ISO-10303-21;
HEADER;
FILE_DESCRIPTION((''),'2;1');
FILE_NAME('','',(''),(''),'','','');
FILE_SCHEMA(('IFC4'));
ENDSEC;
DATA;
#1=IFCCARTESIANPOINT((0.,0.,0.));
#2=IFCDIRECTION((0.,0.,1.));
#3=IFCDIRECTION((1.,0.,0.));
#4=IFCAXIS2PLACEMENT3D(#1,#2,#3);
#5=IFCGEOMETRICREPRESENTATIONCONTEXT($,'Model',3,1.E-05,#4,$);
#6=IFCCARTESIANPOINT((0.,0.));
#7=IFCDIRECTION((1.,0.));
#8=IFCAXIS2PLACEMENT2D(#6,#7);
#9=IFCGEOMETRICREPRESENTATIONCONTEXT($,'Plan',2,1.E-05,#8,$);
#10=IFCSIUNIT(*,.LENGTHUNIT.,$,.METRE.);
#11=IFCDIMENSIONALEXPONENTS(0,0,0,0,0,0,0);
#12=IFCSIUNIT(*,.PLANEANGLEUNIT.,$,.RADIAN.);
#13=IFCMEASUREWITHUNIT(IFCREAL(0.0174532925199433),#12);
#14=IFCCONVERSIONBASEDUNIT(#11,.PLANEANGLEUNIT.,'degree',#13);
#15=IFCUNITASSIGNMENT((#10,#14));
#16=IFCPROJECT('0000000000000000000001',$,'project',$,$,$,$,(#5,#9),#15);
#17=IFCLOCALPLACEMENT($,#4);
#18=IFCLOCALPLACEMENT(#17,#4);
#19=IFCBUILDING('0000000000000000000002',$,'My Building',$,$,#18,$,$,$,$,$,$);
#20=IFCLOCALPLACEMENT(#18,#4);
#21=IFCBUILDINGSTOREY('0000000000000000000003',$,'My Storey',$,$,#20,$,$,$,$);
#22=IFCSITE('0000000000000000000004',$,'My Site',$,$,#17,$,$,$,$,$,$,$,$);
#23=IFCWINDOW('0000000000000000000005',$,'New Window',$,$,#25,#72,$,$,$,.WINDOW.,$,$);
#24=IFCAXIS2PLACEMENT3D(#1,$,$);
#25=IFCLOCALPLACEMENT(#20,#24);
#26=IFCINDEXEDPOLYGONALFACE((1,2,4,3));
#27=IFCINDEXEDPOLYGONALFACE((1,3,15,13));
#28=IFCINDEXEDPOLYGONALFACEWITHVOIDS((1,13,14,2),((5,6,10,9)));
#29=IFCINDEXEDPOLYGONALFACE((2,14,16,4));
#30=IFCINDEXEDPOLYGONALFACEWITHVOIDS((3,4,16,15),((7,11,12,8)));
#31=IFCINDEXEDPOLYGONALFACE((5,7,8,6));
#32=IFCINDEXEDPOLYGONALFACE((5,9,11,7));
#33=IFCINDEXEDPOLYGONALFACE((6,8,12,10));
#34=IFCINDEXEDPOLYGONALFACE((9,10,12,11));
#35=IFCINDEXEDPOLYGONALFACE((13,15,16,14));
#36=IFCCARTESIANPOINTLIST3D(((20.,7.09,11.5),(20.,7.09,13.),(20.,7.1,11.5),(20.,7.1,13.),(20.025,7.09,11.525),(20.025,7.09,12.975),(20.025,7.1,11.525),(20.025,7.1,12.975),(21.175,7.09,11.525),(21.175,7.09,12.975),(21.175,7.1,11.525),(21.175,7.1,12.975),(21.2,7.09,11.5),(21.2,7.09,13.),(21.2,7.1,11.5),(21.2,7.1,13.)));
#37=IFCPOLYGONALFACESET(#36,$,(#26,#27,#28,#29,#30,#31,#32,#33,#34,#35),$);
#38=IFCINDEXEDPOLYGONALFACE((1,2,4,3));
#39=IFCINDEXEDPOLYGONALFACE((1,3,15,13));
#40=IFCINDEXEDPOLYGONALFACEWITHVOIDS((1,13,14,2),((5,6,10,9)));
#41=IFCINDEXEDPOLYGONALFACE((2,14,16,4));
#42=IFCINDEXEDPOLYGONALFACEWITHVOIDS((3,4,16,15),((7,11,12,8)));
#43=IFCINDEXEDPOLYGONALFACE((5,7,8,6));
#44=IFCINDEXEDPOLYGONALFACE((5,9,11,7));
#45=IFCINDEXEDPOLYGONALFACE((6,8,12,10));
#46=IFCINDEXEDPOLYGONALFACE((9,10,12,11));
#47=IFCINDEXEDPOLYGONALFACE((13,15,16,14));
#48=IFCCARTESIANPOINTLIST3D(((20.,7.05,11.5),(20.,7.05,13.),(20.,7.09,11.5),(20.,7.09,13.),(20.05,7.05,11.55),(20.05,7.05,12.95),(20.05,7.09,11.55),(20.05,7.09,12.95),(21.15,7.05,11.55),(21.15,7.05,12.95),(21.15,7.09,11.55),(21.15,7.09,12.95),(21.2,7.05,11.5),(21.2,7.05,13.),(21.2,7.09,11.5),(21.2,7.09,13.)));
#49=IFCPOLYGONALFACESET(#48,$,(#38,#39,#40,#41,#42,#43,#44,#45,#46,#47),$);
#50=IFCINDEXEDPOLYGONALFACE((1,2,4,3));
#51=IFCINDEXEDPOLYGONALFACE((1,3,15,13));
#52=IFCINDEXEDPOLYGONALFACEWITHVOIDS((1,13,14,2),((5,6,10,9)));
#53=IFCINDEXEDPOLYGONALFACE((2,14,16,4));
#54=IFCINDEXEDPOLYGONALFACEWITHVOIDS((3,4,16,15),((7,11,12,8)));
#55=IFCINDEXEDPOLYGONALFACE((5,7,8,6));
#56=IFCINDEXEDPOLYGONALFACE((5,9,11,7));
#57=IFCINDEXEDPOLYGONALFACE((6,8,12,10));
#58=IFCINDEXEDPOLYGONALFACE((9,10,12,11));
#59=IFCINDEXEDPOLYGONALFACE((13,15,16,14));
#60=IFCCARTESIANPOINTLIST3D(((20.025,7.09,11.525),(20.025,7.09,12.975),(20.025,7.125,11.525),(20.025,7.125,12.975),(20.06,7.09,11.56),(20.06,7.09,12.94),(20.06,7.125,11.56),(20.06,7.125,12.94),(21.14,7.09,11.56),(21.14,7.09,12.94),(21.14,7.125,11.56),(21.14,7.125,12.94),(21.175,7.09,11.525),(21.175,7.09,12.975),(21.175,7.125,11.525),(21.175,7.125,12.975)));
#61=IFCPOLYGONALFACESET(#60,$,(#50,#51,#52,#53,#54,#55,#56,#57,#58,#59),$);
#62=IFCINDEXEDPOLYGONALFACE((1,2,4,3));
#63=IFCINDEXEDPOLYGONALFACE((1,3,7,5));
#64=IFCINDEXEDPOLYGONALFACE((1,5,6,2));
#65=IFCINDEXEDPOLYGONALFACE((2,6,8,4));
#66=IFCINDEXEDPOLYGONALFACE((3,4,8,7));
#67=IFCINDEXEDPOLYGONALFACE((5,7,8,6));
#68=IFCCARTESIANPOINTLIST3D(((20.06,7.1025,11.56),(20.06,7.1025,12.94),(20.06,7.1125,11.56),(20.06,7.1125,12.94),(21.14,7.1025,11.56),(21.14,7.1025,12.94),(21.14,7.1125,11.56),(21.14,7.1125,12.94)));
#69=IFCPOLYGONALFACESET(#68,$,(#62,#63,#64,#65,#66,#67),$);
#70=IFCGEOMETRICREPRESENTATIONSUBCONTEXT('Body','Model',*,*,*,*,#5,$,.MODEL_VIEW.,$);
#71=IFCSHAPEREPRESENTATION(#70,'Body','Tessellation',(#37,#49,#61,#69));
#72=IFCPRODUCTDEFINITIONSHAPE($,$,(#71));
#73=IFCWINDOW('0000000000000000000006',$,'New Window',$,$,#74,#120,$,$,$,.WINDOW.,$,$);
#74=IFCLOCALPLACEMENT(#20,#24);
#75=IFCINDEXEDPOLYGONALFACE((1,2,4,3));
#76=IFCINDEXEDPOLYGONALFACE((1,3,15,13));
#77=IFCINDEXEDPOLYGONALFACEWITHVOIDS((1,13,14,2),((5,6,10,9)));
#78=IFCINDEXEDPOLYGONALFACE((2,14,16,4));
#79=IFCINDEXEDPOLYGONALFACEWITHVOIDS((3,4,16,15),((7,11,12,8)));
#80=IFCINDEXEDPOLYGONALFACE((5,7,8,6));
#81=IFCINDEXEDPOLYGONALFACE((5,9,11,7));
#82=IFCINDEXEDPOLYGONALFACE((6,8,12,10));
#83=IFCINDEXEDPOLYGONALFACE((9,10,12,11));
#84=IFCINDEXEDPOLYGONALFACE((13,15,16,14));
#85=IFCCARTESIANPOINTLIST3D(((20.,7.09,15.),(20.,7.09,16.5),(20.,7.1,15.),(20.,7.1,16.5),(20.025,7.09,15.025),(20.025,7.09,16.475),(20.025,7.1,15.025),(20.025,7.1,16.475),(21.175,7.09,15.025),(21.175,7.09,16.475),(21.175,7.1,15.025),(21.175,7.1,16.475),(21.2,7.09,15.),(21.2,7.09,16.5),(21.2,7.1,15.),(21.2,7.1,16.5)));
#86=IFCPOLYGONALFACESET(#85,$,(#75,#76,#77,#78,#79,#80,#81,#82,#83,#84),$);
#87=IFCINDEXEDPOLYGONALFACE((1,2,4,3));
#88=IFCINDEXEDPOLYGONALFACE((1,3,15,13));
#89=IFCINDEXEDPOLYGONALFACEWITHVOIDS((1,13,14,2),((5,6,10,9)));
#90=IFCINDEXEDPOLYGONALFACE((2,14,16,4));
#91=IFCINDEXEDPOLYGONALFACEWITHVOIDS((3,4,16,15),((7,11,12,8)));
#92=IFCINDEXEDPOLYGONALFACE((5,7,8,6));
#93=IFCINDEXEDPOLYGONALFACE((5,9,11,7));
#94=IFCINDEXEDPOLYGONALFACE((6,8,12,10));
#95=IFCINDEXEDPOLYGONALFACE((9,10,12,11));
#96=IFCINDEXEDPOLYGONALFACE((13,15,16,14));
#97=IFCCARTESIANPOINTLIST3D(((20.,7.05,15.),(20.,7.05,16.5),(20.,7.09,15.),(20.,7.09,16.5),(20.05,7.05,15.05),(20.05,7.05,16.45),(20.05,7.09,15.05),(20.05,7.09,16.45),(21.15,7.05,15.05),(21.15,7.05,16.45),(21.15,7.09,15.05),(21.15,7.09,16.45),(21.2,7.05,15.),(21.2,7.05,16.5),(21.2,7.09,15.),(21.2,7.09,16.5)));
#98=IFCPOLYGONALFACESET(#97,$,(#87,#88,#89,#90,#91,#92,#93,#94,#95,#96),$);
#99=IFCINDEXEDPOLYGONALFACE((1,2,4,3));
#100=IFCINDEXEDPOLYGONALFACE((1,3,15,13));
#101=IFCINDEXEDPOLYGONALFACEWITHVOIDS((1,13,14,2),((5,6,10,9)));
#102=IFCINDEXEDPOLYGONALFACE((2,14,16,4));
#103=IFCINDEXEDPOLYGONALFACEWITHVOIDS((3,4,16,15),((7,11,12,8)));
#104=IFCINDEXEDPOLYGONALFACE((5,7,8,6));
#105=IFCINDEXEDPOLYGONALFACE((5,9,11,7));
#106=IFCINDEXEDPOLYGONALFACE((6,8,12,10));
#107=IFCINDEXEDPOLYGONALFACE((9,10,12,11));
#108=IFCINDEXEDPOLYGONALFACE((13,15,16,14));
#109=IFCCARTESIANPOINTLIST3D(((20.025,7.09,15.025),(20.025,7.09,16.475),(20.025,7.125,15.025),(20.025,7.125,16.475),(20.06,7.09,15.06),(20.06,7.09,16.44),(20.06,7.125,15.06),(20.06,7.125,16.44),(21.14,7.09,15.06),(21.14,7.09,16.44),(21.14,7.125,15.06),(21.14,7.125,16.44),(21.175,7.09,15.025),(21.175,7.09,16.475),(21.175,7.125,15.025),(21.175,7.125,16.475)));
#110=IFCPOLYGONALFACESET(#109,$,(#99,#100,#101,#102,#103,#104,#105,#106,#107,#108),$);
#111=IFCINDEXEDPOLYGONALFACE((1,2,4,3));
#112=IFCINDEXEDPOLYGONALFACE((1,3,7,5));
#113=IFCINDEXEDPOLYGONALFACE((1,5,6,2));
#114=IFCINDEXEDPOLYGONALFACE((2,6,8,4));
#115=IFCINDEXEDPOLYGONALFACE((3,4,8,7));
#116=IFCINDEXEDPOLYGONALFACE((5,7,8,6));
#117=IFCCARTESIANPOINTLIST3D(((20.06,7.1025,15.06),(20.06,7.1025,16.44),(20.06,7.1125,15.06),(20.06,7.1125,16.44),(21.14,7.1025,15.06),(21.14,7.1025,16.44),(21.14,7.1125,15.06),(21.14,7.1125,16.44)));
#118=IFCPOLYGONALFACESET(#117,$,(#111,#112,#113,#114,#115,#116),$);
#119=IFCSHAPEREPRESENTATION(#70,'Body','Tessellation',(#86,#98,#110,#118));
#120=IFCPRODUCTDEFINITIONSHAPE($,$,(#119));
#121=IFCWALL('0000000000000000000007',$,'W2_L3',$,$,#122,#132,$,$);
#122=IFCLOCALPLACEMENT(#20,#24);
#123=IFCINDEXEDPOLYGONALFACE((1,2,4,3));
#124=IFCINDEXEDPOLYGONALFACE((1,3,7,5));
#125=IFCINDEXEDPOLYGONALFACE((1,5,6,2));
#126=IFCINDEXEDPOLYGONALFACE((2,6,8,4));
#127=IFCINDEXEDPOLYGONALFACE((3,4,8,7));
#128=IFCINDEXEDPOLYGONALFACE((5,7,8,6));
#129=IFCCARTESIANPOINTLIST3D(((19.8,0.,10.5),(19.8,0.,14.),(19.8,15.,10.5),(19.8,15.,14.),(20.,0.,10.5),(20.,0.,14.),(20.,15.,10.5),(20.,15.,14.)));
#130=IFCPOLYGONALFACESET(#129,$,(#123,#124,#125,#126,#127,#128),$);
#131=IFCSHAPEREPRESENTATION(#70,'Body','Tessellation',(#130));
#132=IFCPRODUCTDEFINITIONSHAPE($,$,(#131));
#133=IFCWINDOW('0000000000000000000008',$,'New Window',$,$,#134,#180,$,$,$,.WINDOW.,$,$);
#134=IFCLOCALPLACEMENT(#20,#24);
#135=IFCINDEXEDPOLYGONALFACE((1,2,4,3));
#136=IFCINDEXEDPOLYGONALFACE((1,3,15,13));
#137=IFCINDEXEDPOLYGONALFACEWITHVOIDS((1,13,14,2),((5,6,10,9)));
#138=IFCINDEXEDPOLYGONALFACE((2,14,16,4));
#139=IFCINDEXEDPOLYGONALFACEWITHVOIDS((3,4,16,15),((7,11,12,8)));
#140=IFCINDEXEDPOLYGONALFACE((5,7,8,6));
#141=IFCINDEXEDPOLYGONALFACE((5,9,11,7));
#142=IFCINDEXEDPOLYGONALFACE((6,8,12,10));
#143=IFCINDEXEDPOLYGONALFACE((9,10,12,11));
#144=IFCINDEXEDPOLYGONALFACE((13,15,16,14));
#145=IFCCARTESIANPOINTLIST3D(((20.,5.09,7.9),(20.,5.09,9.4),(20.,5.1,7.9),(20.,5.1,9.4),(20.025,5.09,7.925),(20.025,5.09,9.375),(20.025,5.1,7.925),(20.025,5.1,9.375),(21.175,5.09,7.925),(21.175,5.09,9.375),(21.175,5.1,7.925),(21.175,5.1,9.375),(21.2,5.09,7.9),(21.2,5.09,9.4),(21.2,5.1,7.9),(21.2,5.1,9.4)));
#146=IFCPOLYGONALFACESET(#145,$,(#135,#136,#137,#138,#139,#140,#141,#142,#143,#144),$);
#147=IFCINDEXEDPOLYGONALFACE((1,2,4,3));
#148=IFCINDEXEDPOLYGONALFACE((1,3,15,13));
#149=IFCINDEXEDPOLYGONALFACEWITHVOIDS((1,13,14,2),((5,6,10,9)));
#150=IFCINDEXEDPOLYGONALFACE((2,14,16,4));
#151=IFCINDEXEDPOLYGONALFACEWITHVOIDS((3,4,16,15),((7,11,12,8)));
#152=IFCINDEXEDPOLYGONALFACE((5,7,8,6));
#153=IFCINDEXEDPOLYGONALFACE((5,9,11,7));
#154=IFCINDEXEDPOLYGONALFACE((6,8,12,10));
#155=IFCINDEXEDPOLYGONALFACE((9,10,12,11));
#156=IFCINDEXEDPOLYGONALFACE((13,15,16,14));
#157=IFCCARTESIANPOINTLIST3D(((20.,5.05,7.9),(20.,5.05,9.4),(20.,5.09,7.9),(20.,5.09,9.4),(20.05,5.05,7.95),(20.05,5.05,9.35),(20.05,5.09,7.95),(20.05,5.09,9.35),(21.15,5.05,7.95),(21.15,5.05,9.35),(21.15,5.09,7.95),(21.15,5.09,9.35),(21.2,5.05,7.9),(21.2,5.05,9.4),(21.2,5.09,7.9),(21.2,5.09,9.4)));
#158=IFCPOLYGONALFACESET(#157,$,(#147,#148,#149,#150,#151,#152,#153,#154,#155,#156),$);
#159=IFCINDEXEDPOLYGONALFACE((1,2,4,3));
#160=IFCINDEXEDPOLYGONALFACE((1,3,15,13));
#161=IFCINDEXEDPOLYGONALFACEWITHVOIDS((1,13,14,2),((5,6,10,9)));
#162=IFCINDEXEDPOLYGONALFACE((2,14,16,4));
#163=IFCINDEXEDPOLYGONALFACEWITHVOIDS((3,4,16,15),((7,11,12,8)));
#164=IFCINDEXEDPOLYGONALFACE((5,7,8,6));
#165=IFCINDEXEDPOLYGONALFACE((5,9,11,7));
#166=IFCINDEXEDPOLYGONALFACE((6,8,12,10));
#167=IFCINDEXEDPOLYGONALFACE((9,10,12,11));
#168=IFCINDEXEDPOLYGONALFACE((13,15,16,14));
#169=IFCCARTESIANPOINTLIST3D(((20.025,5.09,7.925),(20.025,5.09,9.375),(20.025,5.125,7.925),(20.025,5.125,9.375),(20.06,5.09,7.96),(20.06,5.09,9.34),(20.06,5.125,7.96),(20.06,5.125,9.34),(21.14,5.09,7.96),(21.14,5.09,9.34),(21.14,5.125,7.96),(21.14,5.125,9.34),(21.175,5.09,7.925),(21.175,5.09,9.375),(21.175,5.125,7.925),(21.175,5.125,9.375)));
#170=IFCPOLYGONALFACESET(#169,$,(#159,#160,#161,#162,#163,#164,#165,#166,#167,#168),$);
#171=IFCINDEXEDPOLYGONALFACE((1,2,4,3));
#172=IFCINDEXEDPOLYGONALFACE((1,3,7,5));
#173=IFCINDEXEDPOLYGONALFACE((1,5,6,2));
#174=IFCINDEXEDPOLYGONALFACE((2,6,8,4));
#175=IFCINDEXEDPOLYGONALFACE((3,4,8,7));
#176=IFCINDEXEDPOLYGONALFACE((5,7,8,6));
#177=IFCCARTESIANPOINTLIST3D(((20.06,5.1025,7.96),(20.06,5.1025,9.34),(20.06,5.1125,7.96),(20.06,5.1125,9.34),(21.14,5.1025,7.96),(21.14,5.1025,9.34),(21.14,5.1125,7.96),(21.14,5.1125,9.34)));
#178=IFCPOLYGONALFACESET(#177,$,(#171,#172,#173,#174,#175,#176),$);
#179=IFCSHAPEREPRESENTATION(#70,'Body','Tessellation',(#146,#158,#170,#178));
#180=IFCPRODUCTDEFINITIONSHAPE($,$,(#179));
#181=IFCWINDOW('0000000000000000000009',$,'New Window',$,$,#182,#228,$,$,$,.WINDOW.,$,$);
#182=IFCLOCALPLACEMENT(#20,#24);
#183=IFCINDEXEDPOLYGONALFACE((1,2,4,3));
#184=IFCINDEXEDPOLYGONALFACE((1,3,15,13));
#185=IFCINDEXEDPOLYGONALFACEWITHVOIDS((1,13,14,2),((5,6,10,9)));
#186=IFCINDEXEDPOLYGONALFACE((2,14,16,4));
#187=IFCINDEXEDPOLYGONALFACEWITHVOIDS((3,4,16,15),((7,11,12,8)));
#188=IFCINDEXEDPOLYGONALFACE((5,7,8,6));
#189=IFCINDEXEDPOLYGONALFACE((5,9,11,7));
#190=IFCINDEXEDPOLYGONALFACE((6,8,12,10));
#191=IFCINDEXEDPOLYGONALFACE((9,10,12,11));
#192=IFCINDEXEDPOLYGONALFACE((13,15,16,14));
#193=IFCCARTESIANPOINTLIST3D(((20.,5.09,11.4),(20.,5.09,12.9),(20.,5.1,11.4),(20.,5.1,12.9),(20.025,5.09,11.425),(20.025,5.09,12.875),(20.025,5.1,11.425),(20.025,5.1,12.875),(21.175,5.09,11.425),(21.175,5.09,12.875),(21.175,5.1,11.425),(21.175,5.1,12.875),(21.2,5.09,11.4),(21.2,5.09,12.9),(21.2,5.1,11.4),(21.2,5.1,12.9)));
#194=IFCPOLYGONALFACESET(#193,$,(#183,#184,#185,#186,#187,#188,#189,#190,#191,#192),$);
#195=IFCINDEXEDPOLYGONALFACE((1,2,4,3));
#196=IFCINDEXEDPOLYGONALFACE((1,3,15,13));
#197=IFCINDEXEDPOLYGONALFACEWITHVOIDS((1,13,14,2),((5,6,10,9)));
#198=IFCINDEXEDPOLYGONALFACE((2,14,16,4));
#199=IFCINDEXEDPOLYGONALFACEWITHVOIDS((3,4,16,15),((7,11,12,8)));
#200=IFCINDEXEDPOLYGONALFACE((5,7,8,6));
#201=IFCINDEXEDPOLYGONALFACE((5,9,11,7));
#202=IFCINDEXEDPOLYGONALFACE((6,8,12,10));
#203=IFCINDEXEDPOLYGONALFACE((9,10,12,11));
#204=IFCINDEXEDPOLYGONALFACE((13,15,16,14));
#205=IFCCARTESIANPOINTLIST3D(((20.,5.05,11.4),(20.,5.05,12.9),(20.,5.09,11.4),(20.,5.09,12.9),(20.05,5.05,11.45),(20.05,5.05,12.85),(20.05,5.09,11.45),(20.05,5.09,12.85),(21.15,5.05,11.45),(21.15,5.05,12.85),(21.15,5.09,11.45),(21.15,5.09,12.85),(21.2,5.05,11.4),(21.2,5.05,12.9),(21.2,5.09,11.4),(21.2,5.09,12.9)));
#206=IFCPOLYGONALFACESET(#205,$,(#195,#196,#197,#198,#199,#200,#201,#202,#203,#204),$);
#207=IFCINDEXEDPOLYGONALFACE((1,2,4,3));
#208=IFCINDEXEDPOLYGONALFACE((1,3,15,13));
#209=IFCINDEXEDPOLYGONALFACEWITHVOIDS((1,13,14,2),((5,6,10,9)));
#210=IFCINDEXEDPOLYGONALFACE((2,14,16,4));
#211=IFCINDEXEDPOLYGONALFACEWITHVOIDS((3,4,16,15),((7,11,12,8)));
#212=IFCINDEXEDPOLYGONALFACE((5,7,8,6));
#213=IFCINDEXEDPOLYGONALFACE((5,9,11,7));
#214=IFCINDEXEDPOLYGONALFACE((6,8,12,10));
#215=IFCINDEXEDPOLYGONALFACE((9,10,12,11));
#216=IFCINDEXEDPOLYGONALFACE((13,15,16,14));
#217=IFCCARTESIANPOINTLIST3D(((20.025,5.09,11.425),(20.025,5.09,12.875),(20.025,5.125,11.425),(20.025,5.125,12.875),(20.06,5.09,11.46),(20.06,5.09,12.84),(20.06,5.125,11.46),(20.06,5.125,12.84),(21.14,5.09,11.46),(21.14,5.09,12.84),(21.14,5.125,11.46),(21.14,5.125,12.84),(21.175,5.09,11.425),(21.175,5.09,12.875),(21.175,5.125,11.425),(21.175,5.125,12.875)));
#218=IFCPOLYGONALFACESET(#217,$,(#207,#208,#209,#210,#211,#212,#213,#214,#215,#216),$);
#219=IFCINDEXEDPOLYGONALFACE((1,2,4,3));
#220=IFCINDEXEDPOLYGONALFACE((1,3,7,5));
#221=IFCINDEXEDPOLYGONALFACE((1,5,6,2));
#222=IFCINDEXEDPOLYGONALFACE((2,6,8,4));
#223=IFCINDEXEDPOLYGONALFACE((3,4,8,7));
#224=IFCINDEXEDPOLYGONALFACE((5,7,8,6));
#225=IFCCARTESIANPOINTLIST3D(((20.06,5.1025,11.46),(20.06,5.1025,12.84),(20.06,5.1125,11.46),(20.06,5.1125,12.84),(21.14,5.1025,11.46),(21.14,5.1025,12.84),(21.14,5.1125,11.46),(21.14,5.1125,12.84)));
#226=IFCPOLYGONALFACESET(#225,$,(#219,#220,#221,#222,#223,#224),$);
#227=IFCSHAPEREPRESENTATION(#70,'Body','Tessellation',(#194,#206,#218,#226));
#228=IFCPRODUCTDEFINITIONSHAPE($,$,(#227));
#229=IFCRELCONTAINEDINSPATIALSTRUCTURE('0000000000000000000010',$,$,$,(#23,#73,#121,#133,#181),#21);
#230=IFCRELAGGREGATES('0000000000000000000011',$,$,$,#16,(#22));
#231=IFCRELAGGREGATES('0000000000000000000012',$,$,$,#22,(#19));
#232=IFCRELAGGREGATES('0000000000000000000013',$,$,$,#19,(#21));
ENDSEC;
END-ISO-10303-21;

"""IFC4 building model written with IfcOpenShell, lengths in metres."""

from ifc_helpers import new_model, entity, si_unit, converted_unit, frame, origin_with_axes, origin_2d_with_axis, place, context, subcontext, project, spatial, line, indexed_curve, outline, extrude, element, save


model = new_model("IFC4")

# Units and contexts
model_context = context("Model", 3, precision=1e-05, world=origin_with_axes())
plan_context = context("Plan", 2, precision=1e-05, world=origin_2d_with_axis())
body_context = subcontext(model_context, "Body", "Model", "MODEL_VIEW")
ifc_project = project(units=[si_unit("LENGTHUNIT", "METRE"), converted_unit("PLANEANGLEUNIT", "degree", entity("IfcReal", 0.0174532925199433), si_unit("PLANEANGLEUNIT", "RADIAN"), dimensions=[0, 0, 0, 0, 0, 0, 0])], contexts=[model_context, plan_context])

# Site, building, storey
site_placement = place(None, origin_with_axes())
site = spatial("IfcSite", under=ifc_project, at=site_placement, Name="My Site")
building_placement = place(site_placement, origin_with_axes())
building = spatial("IfcBuilding", under=site, at=building_placement, Name="My Building")
storey_placement = place(building_placement, origin_with_axes())
storey = spatial("IfcBuildingStorey", under=building, at=storey_placement, Name="My Storey")

# Windows
for number, where, z_axis, x_axis, name in (
    (1, (20.0, 7.0, 11.5), (0.0, 0.0, 1.0), (1.0, 0.0, 0.0), "New Window"),
    (2, (20.0, 7.0, 15.0), (0.0, 0.0, 1.0), (1.0, 0.0, 0.0), "New Window"),
):
    element("IfcWindow", number, at=place(storey_placement, frame(where, z_axis=z_axis, x_axis=x_axis)), inside=storey, Name=name, PredefinedType="WINDOW", context=body_context, shape_type="SweptSolid", body=[
        extrude(outline(indexed_curve([(0.0, 0.0), (1.2, 0.0), (1.2, 1.5), (0.0, 1.5)], segments=[line(1, 2, 3, 4, 1)]), holes=[indexed_curve([(0.025, 0.025), (1.175, 0.025), (1.175, 1.475), (0.025, 1.475)], segments=[line(1, 2, 3, 4, 1)])]), frame((0.0, 0.09, 0.0), z_axis=(0.0, -1.0, 0.0), x_axis=(1.0, 0.0, 0.0)), (0.0, 0.0, -1.0), 0.01),
        extrude(outline(indexed_curve([(0.0, 0.0), (1.2, 0.0), (1.2, 1.5), (0.0, 1.5)], segments=[line(1, 2, 3, 4, 1)]), holes=[indexed_curve([(0.05, 0.05), (1.15, 0.05), (1.15, 1.45), (0.05, 1.45)], segments=[line(1, 2, 3, 4, 1)])]), frame((0.0, 0.05, 0.0), z_axis=(0.0, -1.0, 0.0), x_axis=(1.0, 0.0, 0.0)), (0.0, 0.0, -1.0), 0.04),
        extrude(outline(indexed_curve([(0.0, 0.0), (1.15, 0.0), (1.15, 1.45), (0.0, 1.45)], segments=[line(1, 2, 3, 4, 1)]), holes=[indexed_curve([(0.035, 0.035), (1.115, 0.035), (1.115, 1.415), (0.035, 1.415)], segments=[line(1, 2, 3, 4, 1)])]), frame((0.025, 0.09, 0.025), z_axis=(0.0, -1.0, 0.0), x_axis=(1.0, 0.0, 0.0)), (0.0, 0.0, -1.0), 0.035),
        extrude(outline(indexed_curve([(0.035, 0.035), (1.115, 0.035), (1.115, 1.415), (0.035, 1.415)], segments=[line(1, 2, 3, 4, 1)])), frame((0.025, 0.1025, 0.025), z_axis=(0.0, -1.0, 0.0), x_axis=(1.0, 0.0, 0.0)), (0.0, 0.0, -1.0), 0.01),
    ])

# Wall
for number, where, z_axis, x_axis, name in (
    (3, (20.0, 0.0, 10.5), (0.0, 0.0, 1.0), (0.0, 1.0, 0.0), "W2_L3"),
):
    element("IfcWall", number, at=place(storey_placement, frame(where, z_axis=z_axis, x_axis=x_axis)), inside=storey, Name=name, context=body_context, shape_type="SweptSolid", body=[
        extrude(outline(indexed_curve([(0.0, 0.0), (0.0, 0.2), (15.0, 0.2), (15.0, 0.0), (0.0, 0.0)], self_intersect=False)), origin_with_axes(), (0.0, 0.0, 1.0), 3.5),
    ])

# Windows
for number, where, z_axis, x_axis, name in (
    (4, (20.0, 5.0, 7.9), (0.0, 0.0, 1.0), (1.0, 0.0, 0.0), "New Window"),
    (5, (20.0, 5.0, 11.4), (0.0, 0.0, 1.0), (1.0, 0.0, 0.0), "New Window"),
):
    element("IfcWindow", number, at=place(storey_placement, frame(where, z_axis=z_axis, x_axis=x_axis)), inside=storey, Name=name, PredefinedType="WINDOW", context=body_context, shape_type="SweptSolid", body=[
        extrude(outline(indexed_curve([(0.0, 0.0), (1.2, 0.0), (1.2, 1.5), (0.0, 1.5)], segments=[line(1, 2, 3, 4, 1)]), holes=[indexed_curve([(0.025, 0.025), (1.175, 0.025), (1.175, 1.475), (0.025, 1.475)], segments=[line(1, 2, 3, 4, 1)])]), frame((0.0, 0.09, 0.0), z_axis=(0.0, -1.0, 0.0), x_axis=(1.0, 0.0, 0.0)), (0.0, 0.0, -1.0), 0.01),
        extrude(outline(indexed_curve([(0.0, 0.0), (1.2, 0.0), (1.2, 1.5), (0.0, 1.5)], segments=[line(1, 2, 3, 4, 1)]), holes=[indexed_curve([(0.05, 0.05), (1.15, 0.05), (1.15, 1.45), (0.05, 1.45)], segments=[line(1, 2, 3, 4, 1)])]), frame((0.0, 0.05, 0.0), z_axis=(0.0, -1.0, 0.0), x_axis=(1.0, 0.0, 0.0)), (0.0, 0.0, -1.0), 0.04),
        extrude(outline(indexed_curve([(0.0, 0.0), (1.15, 0.0), (1.15, 1.45), (0.0, 1.45)], segments=[line(1, 2, 3, 4, 1)]), holes=[indexed_curve([(0.035, 0.035), (1.115, 0.035), (1.115, 1.415), (0.035, 1.415)], segments=[line(1, 2, 3, 4, 1)])]), frame((0.025, 0.09, 0.025), z_axis=(0.0, -1.0, 0.0), x_axis=(1.0, 0.0, 0.0)), (0.0, 0.0, -1.0), 0.035),
        extrude(outline(indexed_curve([(0.035, 0.035), (1.115, 0.035), (1.115, 1.415), (0.035, 1.415)], segments=[line(1, 2, 3, 4, 1)])), frame((0.025, 0.1025, 0.025), z_axis=(0.0, -1.0, 0.0), x_axis=(1.0, 0.0, 0.0)), (0.0, 0.0, -1.0), 0.01),
    ])

save(model, "model.ifc")
